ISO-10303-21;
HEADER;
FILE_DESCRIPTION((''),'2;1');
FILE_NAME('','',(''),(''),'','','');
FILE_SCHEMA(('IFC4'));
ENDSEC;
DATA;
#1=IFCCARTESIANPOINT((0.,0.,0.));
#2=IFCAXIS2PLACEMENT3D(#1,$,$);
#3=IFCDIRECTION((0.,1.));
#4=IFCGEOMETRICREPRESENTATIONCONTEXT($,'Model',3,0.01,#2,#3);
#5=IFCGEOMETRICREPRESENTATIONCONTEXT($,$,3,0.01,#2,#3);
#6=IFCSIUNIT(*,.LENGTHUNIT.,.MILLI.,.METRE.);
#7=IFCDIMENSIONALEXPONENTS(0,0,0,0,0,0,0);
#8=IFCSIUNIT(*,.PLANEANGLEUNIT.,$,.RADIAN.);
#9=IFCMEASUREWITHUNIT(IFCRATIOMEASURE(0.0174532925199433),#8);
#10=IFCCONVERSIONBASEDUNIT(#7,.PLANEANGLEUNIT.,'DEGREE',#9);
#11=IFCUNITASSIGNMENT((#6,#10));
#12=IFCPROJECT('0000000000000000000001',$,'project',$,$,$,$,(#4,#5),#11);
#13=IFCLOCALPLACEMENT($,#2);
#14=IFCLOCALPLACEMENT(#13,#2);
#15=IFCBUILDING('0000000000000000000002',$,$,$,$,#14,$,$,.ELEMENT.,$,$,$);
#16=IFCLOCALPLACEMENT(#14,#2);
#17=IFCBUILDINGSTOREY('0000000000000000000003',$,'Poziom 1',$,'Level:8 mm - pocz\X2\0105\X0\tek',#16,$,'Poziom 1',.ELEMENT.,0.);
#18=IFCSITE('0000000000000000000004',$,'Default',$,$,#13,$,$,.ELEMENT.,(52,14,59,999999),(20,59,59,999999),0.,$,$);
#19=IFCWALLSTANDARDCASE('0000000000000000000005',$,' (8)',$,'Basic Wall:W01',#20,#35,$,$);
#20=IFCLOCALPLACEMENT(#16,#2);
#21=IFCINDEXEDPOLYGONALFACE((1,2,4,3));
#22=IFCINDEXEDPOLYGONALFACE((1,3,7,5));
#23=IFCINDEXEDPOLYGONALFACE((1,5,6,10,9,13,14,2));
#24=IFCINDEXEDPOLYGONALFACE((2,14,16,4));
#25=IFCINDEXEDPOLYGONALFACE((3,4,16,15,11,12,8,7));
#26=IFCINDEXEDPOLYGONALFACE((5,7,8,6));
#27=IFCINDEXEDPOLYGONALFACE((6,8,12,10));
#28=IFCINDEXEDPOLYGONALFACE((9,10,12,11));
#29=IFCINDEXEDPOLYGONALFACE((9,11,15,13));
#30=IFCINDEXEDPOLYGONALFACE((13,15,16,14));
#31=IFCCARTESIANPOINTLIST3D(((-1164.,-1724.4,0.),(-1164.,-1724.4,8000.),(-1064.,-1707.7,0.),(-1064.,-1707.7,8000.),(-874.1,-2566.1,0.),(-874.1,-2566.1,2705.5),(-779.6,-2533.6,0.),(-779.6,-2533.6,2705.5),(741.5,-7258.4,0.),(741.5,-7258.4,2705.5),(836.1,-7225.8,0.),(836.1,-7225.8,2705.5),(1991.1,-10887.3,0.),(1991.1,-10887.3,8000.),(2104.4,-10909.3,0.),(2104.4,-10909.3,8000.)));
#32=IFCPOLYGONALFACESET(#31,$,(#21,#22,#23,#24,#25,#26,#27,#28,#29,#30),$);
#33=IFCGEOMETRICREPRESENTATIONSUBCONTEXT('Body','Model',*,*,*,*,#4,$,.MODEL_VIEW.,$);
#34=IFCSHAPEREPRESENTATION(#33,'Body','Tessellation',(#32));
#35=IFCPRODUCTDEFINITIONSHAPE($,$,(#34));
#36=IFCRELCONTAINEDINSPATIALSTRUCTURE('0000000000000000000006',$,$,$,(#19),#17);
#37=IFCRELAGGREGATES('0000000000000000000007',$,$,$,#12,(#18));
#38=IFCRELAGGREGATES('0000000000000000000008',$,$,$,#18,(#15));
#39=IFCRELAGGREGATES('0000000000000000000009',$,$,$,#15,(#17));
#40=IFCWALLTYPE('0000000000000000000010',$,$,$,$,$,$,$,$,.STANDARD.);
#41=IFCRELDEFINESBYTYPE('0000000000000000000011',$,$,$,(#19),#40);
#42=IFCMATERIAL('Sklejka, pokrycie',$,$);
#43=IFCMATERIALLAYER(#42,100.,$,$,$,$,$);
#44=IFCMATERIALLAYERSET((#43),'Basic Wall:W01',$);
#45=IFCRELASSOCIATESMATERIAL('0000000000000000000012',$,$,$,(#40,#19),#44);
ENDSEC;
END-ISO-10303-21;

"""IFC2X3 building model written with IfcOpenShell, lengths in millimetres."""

from ifc_helpers import new_model, entity, si_unit, converted_unit, direction, frame, frame_2d, origin, place, context, subcontext, project, spatial, polyline, rectangle, outline, extrude, material, layer, layer_set, layer_usage, type_object, element, save


model = new_model("IFC2X3")

# Units and contexts
model_context = context("Model", 3, precision=0.01, world=origin(), true_north=direction((0.0, 1.0)))
context_of_model = context(None, 3, precision=0.01, world=origin(), true_north=direction((0.0, 1.0)))
body_context = subcontext(model_context, "Body", "Model", "MODEL_VIEW")
ifc_project = project(units=[si_unit("LENGTHUNIT", "METRE", prefix="MILLI"), converted_unit("PLANEANGLEUNIT", "DEGREE", entity("IfcRatioMeasure", 0.0174532925199433), si_unit("PLANEANGLEUNIT", "RADIAN"), dimensions=[0, 0, 0, 0, 0, 0, 0])], contexts=[model_context, context_of_model])

# Site, building, storey
site_placement = place(None, origin())
site = spatial("IfcSite", under=ifc_project, at=site_placement, Name="Default", CompositionType="ELEMENT", RefLatitude=(52, 14, 59, 999999), RefLongitude=(20, 59, 59, 999999), RefElevation=0.0)
building_placement = place(site_placement, origin())
building = spatial("IfcBuilding", under=site, at=building_placement, CompositionType="ELEMENT")
storey_placement = place(building_placement, origin())
storey = spatial("IfcBuildingStorey", under=building, at=storey_placement, Name="Poziom 1", ObjectType="Level:8 mm - początek", LongName="Poziom 1", CompositionType="ELEMENT", Elevation=0.0)

# Wall, opening
ifc_material_1 = material(Name="Sklejka, pokrycie")
ifc_layer_1 = layer(ifc_material_1, 100.0)
ifc_layer_set_1 = layer_set([ifc_layer_1], Name="Basic Wall:W01")
ifc_layer_usage_1 = layer_usage(ifc_layer_set_1, "AXIS2", "NEGATIVE", 50.0)
wall_type_1 = type_object("IfcWallType", PredefinedType="STANDARD", material=ifc_layer_set_1)
wall_1_placement = place(storey_placement, frame((2057.1, -10925.6, 0.0), z_axis=(0.0, 0.0, 1.0), x_axis=(-0.325568, 0.945519, 0.0)))
wall_1 = element("IfcWallStandardCase", 1, at=wall_1_placement, inside=storey, type_object=wall_type_1, material=ifc_layer_usage_1, Name=" (8)", ObjectType="Basic Wall:W01", context=body_context, shape_type="SweptSolid", body=[
    extrude(outline(polyline([(0.0, -50.0), (9731.8, -50.0), (9748.6, 50.0), (57.7, 50.0), (0.0, -50.0)])), origin(), (0.0, 0.0, 1.0), 8000.0),
])
opening_1_placement = place(wall_1_placement, origin())
element("IfcOpeningElement", 2, at=opening_1_placement, cuts=wall_1, ObjectType="Opening", context=body_context, shape_type="SweptSolid", body=[
    extrude(rectangle(XDim=2714.3, YDim=4962.6, at=frame_2d((0.0, 0.0), x_axis=(1.0, 0.0))), frame((6377.1, -50.0, 1348.3), z_axis=(0.0, 1.0, 0.0), x_axis=(0.0, 0.0, -1.0)), (0.0, 0.0, 1.0), 100.0),
])

save(model, "model.ifc")
